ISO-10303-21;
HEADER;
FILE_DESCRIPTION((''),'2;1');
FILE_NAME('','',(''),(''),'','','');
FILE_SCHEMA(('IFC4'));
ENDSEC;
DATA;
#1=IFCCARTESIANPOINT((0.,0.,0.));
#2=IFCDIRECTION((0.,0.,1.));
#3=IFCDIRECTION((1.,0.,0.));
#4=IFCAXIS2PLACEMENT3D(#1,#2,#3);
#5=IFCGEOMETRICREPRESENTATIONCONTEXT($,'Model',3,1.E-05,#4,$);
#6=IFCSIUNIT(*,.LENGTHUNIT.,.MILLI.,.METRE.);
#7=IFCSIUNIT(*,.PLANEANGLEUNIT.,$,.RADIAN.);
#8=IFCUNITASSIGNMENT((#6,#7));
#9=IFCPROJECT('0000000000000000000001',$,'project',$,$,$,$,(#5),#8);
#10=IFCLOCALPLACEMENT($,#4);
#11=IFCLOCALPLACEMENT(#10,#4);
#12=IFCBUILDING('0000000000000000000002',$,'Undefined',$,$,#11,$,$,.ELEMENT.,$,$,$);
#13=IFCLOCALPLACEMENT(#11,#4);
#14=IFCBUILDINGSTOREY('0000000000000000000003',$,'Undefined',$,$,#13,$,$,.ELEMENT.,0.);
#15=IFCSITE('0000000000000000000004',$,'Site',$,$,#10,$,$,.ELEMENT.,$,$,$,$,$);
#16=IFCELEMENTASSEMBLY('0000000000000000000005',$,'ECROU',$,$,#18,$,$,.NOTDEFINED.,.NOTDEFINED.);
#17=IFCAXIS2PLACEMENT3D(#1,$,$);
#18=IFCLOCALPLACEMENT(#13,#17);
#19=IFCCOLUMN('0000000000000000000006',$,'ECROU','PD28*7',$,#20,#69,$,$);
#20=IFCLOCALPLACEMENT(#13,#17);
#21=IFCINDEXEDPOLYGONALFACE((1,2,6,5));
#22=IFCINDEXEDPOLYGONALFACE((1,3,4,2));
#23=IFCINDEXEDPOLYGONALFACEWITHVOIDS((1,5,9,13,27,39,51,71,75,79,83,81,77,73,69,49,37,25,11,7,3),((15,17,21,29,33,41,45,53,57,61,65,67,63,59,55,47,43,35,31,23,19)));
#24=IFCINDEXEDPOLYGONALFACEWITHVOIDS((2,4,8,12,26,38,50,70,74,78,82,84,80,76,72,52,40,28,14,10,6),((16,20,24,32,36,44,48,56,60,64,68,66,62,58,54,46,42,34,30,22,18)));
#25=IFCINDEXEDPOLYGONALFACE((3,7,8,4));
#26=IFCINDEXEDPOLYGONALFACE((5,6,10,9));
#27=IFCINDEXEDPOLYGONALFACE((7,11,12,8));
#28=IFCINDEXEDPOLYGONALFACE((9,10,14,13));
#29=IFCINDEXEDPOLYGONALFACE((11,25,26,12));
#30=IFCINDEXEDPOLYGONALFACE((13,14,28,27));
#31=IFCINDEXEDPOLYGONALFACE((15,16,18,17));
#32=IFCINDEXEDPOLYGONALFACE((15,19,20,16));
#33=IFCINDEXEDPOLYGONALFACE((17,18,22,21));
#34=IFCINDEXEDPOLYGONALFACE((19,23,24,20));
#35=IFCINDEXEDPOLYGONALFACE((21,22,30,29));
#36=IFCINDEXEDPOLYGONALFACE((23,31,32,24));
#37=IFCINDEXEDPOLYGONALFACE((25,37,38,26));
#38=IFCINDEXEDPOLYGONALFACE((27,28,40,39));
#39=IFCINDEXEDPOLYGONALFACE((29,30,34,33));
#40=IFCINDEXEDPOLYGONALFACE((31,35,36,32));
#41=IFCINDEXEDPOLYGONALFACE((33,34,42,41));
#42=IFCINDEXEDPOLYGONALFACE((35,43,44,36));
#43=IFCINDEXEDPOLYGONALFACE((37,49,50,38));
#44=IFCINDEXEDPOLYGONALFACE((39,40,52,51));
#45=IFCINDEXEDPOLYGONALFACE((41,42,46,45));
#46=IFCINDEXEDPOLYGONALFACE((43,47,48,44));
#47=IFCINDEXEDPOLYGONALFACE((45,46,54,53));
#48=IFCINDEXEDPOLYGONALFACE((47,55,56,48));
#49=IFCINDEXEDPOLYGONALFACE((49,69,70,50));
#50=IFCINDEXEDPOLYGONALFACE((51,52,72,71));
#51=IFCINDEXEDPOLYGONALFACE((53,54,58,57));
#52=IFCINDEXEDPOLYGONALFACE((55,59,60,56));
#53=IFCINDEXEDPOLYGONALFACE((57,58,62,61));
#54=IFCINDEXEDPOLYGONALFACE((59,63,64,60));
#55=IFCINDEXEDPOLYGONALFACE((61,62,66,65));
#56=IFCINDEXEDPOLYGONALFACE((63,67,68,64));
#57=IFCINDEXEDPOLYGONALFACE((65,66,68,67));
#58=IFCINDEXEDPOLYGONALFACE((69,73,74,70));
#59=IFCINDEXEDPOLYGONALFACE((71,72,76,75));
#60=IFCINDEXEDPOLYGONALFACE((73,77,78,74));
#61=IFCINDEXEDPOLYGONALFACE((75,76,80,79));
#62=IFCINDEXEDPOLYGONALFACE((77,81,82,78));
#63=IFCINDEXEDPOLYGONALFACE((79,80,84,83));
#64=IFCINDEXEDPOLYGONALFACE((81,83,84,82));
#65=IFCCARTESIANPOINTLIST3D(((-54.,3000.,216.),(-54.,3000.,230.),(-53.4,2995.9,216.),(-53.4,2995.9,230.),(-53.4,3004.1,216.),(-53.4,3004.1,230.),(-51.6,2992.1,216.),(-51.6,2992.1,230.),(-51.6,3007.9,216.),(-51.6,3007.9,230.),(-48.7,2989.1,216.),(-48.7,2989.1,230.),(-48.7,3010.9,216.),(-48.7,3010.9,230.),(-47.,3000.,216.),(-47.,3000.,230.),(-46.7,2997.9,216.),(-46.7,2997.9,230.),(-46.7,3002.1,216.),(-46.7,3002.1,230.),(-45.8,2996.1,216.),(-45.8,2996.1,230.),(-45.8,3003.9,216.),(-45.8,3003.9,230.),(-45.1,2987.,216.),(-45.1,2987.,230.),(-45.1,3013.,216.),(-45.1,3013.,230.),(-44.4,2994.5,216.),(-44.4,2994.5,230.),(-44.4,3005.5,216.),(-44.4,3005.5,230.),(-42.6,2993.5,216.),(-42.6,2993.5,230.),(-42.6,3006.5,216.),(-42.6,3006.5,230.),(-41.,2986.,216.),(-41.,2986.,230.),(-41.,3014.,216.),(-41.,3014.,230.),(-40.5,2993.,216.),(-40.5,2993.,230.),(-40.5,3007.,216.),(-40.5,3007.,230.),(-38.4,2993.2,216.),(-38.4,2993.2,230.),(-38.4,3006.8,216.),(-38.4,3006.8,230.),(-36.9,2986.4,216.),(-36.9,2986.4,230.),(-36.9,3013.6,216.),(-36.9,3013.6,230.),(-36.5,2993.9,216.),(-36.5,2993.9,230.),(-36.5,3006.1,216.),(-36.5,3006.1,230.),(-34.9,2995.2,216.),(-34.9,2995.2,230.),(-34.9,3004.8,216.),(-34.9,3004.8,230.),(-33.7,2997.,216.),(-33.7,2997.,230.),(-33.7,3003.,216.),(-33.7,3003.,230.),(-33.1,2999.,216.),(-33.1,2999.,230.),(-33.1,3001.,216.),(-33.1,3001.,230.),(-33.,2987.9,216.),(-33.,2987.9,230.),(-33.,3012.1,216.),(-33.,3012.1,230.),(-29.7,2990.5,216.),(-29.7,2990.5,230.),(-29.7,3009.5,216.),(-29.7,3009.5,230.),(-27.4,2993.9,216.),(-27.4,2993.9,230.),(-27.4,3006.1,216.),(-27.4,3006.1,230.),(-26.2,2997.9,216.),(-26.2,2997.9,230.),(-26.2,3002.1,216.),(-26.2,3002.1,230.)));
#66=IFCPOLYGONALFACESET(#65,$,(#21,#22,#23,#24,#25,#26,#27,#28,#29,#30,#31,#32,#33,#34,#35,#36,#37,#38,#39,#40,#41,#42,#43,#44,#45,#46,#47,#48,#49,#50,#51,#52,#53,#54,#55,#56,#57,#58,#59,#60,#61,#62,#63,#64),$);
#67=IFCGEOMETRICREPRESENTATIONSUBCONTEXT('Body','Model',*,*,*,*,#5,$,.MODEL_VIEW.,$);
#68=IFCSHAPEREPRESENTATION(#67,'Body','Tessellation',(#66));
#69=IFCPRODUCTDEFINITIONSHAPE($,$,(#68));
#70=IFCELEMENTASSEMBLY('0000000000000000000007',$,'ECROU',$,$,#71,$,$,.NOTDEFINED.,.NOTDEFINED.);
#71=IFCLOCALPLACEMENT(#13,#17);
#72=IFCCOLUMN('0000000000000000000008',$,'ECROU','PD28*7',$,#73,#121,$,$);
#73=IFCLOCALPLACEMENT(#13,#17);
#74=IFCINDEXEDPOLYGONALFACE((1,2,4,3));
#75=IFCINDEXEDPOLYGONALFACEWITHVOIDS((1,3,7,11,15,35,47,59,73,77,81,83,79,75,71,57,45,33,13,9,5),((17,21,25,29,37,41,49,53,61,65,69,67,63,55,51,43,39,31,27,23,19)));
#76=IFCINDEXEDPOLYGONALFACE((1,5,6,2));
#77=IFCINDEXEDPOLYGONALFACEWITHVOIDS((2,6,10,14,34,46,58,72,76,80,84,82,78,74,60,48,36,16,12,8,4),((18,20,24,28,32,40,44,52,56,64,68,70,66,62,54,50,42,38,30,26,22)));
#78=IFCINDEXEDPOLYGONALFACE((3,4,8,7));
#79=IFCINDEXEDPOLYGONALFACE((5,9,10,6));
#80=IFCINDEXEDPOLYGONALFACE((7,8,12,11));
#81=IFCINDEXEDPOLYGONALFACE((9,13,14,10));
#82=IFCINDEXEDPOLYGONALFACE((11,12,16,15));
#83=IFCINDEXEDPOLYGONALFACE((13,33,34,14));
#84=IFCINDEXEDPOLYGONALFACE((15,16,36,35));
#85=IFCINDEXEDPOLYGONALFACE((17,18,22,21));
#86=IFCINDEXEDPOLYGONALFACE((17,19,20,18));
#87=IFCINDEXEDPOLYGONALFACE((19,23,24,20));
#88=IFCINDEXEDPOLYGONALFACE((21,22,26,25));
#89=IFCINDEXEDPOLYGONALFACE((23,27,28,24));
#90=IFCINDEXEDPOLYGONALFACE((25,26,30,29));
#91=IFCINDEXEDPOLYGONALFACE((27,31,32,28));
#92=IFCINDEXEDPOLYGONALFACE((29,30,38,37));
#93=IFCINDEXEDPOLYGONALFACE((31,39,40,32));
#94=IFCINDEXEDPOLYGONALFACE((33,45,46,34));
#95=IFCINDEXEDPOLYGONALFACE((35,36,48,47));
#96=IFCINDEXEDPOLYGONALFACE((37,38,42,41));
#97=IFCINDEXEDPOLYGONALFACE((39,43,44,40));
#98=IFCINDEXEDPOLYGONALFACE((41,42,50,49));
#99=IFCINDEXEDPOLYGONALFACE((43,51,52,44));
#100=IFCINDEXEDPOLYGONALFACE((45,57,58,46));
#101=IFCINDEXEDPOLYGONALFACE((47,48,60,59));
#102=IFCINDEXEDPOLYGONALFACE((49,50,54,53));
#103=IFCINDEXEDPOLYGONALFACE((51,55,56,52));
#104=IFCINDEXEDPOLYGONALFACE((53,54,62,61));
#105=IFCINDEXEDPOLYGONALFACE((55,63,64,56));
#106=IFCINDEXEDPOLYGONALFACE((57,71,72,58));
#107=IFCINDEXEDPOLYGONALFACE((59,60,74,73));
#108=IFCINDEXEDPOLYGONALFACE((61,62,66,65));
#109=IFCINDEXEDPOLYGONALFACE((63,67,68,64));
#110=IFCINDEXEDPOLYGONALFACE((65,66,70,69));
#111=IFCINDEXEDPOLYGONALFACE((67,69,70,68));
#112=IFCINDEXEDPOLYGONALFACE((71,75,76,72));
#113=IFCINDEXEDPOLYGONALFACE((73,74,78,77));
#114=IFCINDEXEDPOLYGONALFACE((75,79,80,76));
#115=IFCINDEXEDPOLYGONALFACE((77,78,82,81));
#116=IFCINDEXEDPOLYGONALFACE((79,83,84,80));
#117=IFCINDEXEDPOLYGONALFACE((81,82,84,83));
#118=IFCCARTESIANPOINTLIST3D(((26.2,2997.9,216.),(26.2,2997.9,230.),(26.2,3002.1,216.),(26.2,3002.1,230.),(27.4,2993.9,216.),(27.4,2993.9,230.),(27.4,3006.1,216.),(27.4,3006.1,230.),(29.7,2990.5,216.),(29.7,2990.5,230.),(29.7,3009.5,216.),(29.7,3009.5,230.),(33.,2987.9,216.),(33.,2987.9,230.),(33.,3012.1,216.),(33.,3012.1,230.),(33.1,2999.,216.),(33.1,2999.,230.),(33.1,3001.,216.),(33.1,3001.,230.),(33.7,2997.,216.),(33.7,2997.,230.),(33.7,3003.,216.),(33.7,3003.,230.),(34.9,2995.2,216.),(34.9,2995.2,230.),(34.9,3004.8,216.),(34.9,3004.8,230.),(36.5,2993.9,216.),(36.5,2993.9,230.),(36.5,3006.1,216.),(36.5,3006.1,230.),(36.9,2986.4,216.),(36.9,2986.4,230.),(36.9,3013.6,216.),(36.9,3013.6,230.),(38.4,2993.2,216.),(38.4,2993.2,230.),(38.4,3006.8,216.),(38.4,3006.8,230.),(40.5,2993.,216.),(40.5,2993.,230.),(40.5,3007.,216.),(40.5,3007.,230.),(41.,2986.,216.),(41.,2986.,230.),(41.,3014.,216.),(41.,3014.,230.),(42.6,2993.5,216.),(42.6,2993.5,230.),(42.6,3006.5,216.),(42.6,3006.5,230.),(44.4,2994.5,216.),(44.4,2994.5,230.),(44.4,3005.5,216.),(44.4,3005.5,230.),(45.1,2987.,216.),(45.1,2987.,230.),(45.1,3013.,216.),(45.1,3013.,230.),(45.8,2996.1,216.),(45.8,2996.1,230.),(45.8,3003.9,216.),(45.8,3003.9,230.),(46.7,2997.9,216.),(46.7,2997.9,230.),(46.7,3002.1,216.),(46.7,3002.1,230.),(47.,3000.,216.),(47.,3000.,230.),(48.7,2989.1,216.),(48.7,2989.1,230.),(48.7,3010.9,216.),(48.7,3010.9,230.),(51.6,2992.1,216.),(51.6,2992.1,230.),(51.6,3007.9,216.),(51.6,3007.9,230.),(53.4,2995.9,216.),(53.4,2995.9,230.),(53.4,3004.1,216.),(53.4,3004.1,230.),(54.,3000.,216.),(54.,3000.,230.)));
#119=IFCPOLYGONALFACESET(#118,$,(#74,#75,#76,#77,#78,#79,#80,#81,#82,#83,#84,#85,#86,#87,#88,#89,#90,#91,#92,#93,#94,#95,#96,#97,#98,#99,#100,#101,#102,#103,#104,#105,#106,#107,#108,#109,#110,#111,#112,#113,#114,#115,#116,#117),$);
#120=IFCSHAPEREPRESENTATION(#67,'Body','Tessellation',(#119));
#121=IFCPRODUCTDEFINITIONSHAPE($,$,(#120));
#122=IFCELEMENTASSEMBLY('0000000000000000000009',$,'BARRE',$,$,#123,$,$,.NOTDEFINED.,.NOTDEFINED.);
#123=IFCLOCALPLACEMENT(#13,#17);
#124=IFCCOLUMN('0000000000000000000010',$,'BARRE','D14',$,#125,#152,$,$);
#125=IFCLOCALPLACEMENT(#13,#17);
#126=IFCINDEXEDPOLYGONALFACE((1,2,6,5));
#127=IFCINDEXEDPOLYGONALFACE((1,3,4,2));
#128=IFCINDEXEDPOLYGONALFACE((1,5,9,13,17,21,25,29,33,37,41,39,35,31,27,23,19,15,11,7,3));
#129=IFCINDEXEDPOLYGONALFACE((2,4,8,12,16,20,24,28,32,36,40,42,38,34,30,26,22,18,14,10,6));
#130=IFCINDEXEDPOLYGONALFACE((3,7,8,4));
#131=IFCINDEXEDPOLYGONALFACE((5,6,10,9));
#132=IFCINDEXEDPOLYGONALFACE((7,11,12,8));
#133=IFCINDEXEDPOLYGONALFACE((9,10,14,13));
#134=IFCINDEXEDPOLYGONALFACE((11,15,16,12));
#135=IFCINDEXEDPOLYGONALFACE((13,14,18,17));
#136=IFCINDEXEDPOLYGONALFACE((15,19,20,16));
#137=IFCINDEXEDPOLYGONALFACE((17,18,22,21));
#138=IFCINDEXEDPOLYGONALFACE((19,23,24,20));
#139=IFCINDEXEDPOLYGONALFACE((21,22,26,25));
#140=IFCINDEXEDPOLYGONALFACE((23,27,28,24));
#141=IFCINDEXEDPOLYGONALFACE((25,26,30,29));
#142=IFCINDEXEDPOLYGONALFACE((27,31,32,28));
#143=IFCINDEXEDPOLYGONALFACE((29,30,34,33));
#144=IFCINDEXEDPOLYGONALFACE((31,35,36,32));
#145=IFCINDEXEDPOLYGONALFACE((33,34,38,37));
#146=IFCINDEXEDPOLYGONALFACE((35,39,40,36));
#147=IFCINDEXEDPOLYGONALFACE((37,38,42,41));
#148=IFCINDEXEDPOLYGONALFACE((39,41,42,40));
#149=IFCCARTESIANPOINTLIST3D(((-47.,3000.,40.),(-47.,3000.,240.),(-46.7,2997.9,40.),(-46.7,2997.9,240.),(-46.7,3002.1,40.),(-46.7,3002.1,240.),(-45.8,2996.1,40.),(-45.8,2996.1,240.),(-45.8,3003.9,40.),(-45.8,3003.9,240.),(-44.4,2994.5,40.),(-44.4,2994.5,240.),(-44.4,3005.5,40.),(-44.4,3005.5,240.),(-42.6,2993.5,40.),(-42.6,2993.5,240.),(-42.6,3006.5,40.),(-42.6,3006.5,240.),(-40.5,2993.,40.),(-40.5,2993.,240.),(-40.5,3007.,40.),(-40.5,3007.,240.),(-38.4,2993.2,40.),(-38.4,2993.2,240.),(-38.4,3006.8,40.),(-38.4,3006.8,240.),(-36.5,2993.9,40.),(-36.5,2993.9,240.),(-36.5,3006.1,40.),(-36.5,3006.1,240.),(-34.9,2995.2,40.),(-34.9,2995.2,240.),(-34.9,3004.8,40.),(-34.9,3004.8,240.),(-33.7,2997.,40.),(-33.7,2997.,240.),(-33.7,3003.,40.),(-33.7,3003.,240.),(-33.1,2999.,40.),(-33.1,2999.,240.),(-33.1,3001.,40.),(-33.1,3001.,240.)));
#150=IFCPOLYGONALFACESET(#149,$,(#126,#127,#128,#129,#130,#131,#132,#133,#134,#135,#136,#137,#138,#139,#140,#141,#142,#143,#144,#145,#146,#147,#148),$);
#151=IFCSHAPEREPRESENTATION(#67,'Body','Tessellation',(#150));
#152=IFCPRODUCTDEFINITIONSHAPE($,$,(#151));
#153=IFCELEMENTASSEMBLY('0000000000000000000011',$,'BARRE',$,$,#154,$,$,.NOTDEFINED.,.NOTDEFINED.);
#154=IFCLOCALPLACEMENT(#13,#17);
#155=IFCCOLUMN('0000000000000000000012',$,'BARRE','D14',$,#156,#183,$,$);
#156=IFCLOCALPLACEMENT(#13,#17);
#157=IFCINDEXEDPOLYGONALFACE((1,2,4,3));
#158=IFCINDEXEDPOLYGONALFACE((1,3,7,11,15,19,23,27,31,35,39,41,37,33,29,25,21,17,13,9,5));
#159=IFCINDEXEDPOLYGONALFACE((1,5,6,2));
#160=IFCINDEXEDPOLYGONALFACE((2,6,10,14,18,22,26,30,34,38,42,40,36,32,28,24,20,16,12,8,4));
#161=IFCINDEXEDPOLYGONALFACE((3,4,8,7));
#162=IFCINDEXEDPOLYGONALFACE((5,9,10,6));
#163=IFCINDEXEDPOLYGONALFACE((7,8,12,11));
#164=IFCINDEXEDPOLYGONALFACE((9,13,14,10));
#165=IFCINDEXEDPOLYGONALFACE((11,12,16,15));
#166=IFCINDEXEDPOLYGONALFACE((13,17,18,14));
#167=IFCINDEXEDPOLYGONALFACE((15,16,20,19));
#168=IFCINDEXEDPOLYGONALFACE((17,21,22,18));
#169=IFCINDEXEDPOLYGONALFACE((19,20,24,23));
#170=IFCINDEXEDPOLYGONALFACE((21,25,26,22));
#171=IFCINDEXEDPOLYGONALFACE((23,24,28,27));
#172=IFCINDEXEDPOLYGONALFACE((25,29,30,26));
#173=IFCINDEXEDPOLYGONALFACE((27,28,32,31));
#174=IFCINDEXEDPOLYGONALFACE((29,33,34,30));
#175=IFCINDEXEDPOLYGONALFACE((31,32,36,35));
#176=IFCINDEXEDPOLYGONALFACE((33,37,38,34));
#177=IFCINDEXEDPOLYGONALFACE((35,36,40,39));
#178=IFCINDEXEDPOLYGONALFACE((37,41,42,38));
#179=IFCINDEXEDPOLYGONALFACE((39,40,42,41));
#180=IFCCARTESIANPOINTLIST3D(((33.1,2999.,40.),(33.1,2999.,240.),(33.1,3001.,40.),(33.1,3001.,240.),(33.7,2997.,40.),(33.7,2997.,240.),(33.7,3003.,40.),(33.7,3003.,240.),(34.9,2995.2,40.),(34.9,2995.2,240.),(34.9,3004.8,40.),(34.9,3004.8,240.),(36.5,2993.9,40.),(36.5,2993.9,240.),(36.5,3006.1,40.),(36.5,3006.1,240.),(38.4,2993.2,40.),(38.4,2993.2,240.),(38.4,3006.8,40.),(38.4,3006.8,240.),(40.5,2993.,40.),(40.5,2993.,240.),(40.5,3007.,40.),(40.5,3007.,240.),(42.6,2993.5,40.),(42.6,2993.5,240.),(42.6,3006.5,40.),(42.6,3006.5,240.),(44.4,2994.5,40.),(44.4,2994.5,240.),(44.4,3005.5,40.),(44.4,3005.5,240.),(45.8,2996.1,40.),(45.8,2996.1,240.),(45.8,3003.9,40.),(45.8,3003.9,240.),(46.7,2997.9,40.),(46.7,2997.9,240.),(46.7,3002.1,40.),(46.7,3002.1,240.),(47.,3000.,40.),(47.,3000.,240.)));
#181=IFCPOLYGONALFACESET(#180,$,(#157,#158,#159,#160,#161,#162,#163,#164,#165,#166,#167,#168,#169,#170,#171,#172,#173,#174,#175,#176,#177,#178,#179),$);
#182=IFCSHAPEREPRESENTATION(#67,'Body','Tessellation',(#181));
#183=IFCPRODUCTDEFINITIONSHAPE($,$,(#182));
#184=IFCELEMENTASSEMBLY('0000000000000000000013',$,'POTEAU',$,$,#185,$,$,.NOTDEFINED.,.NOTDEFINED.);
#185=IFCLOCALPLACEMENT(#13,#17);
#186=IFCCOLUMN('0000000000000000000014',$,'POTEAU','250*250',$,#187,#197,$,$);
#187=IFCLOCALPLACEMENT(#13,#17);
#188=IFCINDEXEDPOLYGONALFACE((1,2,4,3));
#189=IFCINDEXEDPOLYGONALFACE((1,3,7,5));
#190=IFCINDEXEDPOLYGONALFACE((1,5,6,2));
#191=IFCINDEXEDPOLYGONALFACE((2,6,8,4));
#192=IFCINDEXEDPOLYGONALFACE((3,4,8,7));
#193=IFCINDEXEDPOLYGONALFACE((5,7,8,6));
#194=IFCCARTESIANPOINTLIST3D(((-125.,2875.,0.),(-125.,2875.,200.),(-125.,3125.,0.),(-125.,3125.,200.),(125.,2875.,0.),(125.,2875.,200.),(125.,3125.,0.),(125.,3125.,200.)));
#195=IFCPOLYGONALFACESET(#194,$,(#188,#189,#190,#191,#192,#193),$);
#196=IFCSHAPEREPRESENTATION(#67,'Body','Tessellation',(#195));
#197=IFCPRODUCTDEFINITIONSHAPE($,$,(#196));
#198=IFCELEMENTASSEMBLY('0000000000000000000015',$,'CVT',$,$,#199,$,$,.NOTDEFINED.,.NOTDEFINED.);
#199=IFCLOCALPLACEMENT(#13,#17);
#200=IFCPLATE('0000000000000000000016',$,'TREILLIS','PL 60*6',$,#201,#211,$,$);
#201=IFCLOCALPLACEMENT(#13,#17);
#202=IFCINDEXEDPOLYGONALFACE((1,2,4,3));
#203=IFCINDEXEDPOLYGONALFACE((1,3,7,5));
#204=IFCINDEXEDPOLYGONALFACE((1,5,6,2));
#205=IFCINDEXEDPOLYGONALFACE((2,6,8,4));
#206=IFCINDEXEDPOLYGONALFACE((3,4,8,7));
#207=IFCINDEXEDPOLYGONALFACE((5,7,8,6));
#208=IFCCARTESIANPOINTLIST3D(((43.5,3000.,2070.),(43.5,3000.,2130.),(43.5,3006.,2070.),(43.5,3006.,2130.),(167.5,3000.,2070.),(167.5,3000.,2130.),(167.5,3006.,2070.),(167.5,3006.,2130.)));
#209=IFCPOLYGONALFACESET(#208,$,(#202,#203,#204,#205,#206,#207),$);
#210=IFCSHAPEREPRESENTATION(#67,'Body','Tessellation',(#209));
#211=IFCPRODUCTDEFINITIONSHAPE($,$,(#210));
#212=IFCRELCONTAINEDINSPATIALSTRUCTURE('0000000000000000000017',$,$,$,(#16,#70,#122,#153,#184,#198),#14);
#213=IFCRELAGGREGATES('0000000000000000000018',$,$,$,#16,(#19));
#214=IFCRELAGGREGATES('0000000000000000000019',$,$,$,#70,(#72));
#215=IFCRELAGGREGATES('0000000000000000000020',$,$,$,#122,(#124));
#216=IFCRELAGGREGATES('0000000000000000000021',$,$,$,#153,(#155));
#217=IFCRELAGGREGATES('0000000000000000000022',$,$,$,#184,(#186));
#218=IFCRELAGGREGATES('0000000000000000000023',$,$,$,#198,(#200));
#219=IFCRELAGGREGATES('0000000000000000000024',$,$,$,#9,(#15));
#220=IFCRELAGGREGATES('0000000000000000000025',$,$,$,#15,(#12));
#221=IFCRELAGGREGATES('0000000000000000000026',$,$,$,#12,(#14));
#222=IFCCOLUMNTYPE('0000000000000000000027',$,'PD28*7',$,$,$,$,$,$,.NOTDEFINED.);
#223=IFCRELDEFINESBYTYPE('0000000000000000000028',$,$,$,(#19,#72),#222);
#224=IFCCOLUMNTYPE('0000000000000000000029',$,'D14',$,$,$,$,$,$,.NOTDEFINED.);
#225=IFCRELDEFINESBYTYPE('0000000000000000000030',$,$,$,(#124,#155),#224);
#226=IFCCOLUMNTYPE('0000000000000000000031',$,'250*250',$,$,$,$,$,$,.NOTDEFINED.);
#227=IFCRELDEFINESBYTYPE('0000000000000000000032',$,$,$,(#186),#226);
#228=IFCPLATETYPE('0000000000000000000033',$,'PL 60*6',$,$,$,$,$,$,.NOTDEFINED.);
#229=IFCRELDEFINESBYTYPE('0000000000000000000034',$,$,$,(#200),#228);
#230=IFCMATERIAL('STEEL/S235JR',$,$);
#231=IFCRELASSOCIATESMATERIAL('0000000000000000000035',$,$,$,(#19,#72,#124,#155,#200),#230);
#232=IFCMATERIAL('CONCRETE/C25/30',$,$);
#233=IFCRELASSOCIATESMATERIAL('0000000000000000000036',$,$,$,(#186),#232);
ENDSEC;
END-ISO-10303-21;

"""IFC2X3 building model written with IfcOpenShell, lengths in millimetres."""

from ifc_helpers import new_model, si_unit, frame, origin_with_axes, origin_2d_with_axis, place, context, subcontext, project, spatial, polyline, rectangle, circle, hollow_circle, outline, extrude, material, type_object, element, aggregate, save


model = new_model("IFC2X3")

# Units and contexts
model_context = context("Model", 3, precision=1e-05, world=origin_with_axes())
body_context = subcontext(model_context, "Body", "Model", "MODEL_VIEW")
ifc_project = project(units=[si_unit("LENGTHUNIT", "METRE", prefix="MILLI"), si_unit("PLANEANGLEUNIT", "RADIAN")], contexts=[model_context])

# Site, building, storey
site_placement = place(None, origin_with_axes())
site = spatial("IfcSite", under=ifc_project, at=site_placement, Name="Site", CompositionType="ELEMENT")
building_placement = place(site_placement, origin_with_axes())
building = spatial("IfcBuilding", under=site, at=building_placement, Name="Undefined", CompositionType="ELEMENT")
storey_placement = place(building_placement, origin_with_axes())
storey = spatial("IfcBuildingStorey", under=building, at=storey_placement, Name="Undefined", CompositionType="ELEMENT", Elevation=0.0)

# Element assemblies, columns
assembly_1_placement = place(storey_placement, origin_with_axes())
assembly_1 = element("IfcElementAssembly", 1, at=assembly_1_placement, inside=storey, Name="ECROU", AssemblyPlace="NOTDEFINED", PredefinedType="NOTDEFINED")
ifc_material_1 = material(Name="STEEL/S235JR")
column_type_1 = type_object("IfcColumnType", Name="PD28*7", PredefinedType="NOTDEFINED")
column_1_placement = place(assembly_1_placement, frame((-40.0, 3000.0, 230.0), z_axis=(0.0, 0.0, -1.0), x_axis=(0.0, -1.0, 0.0)))
column_1 = element("IfcColumn", 2, at=column_1_placement, type_object=column_type_1, material=ifc_material_1, Name="ECROU", Description="PD28*7", context=body_context, shape_type="SweptSolid", body=[
    extrude(hollow_circle(Radius=14.0, WallThickness=7.0, at=origin_2d_with_axis()), frame((0.0, 0.0, 14.0), z_axis=(0.0, 0.0, -1.0), x_axis=(0.0, 1.0, 0.0)), (0.0, 0.0, 1.0), 14.0),
])
aggregate(assembly_1, [column_1])
assembly_2_placement = place(storey_placement, origin_with_axes())
assembly_2 = element("IfcElementAssembly", 3, at=assembly_2_placement, inside=storey, Name="ECROU", AssemblyPlace="NOTDEFINED", PredefinedType="NOTDEFINED")
column_2_placement = place(assembly_2_placement, frame((40.0, 3000.0, 230.0), z_axis=(0.0, 0.0, -1.0), x_axis=(0.0, 1.0, 0.0)))
column_2 = element("IfcColumn", 4, at=column_2_placement, type_object=column_type_1, material=ifc_material_1, Name="ECROU", Description="PD28*7", context=body_context, shape_type="SweptSolid", body=[
    extrude(hollow_circle(Radius=14.0, WallThickness=7.0, at=origin_2d_with_axis()), frame((0.0, 0.0, 14.0), z_axis=(0.0, 0.0, -1.0), x_axis=(0.0, 1.0, 0.0)), (0.0, 0.0, 1.0), 14.0),
])
aggregate(assembly_2, [column_2])
assembly_3_placement = place(storey_placement, origin_with_axes())
assembly_3 = element("IfcElementAssembly", 5, at=assembly_3_placement, inside=storey, Name="BARRE", AssemblyPlace="NOTDEFINED", PredefinedType="NOTDEFINED")
column_type_2 = type_object("IfcColumnType", Name="D14", PredefinedType="NOTDEFINED")
column_3_placement = place(assembly_3_placement, frame((-40.0, 3000.0, 240.0), z_axis=(0.0, 0.0, -1.0), x_axis=(0.0, -1.0, 0.0)))
column_3 = element("IfcColumn", 6, at=column_3_placement, type_object=column_type_2, material=ifc_material_1, Name="BARRE", Description="D14", context=body_context, shape_type="SweptSolid", body=[
    extrude(circle(Radius=7.0, at=origin_2d_with_axis()), frame((0.0, 0.0, 200.0), z_axis=(0.0, 0.0, -1.0), x_axis=(0.0, 1.0, 0.0)), (0.0, 0.0, 1.0), 200.0),
])
aggregate(assembly_3, [column_3])
assembly_4_placement = place(storey_placement, origin_with_axes())
assembly_4 = element("IfcElementAssembly", 7, at=assembly_4_placement, inside=storey, Name="BARRE", AssemblyPlace="NOTDEFINED", PredefinedType="NOTDEFINED")
column_4_placement = place(assembly_4_placement, frame((40.0, 3000.0, 240.0), z_axis=(0.0, 0.0, -1.0), x_axis=(0.0, 1.0, 0.0)))
column_4 = element("IfcColumn", 8, at=column_4_placement, type_object=column_type_2, material=ifc_material_1, Name="BARRE", Description="D14", context=body_context, shape_type="SweptSolid", body=[
    extrude(circle(Radius=7.0, at=origin_2d_with_axis()), frame((0.0, 0.0, 200.0), z_axis=(0.0, 0.0, -1.0), x_axis=(0.0, 1.0, 0.0)), (0.0, 0.0, 1.0), 200.0),
])
aggregate(assembly_4, [column_4])
assembly_5_placement = place(storey_placement, origin_with_axes())
assembly_5 = element("IfcElementAssembly", 9, at=assembly_5_placement, inside=storey, Name="POTEAU", AssemblyPlace="NOTDEFINED", PredefinedType="NOTDEFINED")
ifc_material_2 = material(Name="CONCRETE/C25/30")
column_type_3 = type_object("IfcColumnType", Name="250*250", PredefinedType="NOTDEFINED")
column_5_placement = place(assembly_5_placement, frame((0.0, 3000.0, 0.0), z_axis=(0.0, 0.0, 1.0), x_axis=(0.0, 1.0, 0.0)))
column_5 = element("IfcColumn", 10, at=column_5_placement, type_object=column_type_3, material=ifc_material_2, Name="POTEAU", Description="250*250", context=body_context, shape_type="SweptSolid", body=[
    extrude(rectangle(XDim=250.0, YDim=250.0, at=origin_2d_with_axis()), frame((0.0, 0.0, 200.0), z_axis=(0.0, 0.0, -1.0), x_axis=(0.0, 1.0, 0.0)), (0.0, 0.0, 1.0), 200.0),
])
aggregate(assembly_5, [column_5])

# Element assembly, plate
assembly_6_placement = place(storey_placement, origin_with_axes())
assembly_6 = element("IfcElementAssembly", 11, at=assembly_6_placement, inside=storey, Name="CVT", AssemblyPlace="NOTDEFINED", PredefinedType="NOTDEFINED")
plate_type_1 = type_object("IfcPlateType", Name="PL 60*6", PredefinedType="NOTDEFINED")
plate_1_placement = place(assembly_6_placement, frame((43.5, 3003.0, 2100.0), z_axis=(0.0, -1.0, 0.0), x_axis=(1.0, 0.0, 0.0)))
plate_1 = element("IfcPlate", 12, at=plate_1_placement, type_object=plate_type_1, material=ifc_material_1, Name="TREILLIS", Description="PL 60*6", context=body_context, shape_type="SweptSolid", body=[
    extrude(outline(polyline([(0.0, -30.0), (0.0, 30.0), (124.0, 30.0), (124.0, -30.0), (0.0, -30.0)])), frame((0.0, 0.0, -3.0), z_axis=(0.0, 0.0, 1.0), x_axis=(1.0, 0.0, 0.0)), (0.0, 0.0, 1.0), 6.0),
])
aggregate(assembly_6, [plate_1])

save(model, "model.ifc")
